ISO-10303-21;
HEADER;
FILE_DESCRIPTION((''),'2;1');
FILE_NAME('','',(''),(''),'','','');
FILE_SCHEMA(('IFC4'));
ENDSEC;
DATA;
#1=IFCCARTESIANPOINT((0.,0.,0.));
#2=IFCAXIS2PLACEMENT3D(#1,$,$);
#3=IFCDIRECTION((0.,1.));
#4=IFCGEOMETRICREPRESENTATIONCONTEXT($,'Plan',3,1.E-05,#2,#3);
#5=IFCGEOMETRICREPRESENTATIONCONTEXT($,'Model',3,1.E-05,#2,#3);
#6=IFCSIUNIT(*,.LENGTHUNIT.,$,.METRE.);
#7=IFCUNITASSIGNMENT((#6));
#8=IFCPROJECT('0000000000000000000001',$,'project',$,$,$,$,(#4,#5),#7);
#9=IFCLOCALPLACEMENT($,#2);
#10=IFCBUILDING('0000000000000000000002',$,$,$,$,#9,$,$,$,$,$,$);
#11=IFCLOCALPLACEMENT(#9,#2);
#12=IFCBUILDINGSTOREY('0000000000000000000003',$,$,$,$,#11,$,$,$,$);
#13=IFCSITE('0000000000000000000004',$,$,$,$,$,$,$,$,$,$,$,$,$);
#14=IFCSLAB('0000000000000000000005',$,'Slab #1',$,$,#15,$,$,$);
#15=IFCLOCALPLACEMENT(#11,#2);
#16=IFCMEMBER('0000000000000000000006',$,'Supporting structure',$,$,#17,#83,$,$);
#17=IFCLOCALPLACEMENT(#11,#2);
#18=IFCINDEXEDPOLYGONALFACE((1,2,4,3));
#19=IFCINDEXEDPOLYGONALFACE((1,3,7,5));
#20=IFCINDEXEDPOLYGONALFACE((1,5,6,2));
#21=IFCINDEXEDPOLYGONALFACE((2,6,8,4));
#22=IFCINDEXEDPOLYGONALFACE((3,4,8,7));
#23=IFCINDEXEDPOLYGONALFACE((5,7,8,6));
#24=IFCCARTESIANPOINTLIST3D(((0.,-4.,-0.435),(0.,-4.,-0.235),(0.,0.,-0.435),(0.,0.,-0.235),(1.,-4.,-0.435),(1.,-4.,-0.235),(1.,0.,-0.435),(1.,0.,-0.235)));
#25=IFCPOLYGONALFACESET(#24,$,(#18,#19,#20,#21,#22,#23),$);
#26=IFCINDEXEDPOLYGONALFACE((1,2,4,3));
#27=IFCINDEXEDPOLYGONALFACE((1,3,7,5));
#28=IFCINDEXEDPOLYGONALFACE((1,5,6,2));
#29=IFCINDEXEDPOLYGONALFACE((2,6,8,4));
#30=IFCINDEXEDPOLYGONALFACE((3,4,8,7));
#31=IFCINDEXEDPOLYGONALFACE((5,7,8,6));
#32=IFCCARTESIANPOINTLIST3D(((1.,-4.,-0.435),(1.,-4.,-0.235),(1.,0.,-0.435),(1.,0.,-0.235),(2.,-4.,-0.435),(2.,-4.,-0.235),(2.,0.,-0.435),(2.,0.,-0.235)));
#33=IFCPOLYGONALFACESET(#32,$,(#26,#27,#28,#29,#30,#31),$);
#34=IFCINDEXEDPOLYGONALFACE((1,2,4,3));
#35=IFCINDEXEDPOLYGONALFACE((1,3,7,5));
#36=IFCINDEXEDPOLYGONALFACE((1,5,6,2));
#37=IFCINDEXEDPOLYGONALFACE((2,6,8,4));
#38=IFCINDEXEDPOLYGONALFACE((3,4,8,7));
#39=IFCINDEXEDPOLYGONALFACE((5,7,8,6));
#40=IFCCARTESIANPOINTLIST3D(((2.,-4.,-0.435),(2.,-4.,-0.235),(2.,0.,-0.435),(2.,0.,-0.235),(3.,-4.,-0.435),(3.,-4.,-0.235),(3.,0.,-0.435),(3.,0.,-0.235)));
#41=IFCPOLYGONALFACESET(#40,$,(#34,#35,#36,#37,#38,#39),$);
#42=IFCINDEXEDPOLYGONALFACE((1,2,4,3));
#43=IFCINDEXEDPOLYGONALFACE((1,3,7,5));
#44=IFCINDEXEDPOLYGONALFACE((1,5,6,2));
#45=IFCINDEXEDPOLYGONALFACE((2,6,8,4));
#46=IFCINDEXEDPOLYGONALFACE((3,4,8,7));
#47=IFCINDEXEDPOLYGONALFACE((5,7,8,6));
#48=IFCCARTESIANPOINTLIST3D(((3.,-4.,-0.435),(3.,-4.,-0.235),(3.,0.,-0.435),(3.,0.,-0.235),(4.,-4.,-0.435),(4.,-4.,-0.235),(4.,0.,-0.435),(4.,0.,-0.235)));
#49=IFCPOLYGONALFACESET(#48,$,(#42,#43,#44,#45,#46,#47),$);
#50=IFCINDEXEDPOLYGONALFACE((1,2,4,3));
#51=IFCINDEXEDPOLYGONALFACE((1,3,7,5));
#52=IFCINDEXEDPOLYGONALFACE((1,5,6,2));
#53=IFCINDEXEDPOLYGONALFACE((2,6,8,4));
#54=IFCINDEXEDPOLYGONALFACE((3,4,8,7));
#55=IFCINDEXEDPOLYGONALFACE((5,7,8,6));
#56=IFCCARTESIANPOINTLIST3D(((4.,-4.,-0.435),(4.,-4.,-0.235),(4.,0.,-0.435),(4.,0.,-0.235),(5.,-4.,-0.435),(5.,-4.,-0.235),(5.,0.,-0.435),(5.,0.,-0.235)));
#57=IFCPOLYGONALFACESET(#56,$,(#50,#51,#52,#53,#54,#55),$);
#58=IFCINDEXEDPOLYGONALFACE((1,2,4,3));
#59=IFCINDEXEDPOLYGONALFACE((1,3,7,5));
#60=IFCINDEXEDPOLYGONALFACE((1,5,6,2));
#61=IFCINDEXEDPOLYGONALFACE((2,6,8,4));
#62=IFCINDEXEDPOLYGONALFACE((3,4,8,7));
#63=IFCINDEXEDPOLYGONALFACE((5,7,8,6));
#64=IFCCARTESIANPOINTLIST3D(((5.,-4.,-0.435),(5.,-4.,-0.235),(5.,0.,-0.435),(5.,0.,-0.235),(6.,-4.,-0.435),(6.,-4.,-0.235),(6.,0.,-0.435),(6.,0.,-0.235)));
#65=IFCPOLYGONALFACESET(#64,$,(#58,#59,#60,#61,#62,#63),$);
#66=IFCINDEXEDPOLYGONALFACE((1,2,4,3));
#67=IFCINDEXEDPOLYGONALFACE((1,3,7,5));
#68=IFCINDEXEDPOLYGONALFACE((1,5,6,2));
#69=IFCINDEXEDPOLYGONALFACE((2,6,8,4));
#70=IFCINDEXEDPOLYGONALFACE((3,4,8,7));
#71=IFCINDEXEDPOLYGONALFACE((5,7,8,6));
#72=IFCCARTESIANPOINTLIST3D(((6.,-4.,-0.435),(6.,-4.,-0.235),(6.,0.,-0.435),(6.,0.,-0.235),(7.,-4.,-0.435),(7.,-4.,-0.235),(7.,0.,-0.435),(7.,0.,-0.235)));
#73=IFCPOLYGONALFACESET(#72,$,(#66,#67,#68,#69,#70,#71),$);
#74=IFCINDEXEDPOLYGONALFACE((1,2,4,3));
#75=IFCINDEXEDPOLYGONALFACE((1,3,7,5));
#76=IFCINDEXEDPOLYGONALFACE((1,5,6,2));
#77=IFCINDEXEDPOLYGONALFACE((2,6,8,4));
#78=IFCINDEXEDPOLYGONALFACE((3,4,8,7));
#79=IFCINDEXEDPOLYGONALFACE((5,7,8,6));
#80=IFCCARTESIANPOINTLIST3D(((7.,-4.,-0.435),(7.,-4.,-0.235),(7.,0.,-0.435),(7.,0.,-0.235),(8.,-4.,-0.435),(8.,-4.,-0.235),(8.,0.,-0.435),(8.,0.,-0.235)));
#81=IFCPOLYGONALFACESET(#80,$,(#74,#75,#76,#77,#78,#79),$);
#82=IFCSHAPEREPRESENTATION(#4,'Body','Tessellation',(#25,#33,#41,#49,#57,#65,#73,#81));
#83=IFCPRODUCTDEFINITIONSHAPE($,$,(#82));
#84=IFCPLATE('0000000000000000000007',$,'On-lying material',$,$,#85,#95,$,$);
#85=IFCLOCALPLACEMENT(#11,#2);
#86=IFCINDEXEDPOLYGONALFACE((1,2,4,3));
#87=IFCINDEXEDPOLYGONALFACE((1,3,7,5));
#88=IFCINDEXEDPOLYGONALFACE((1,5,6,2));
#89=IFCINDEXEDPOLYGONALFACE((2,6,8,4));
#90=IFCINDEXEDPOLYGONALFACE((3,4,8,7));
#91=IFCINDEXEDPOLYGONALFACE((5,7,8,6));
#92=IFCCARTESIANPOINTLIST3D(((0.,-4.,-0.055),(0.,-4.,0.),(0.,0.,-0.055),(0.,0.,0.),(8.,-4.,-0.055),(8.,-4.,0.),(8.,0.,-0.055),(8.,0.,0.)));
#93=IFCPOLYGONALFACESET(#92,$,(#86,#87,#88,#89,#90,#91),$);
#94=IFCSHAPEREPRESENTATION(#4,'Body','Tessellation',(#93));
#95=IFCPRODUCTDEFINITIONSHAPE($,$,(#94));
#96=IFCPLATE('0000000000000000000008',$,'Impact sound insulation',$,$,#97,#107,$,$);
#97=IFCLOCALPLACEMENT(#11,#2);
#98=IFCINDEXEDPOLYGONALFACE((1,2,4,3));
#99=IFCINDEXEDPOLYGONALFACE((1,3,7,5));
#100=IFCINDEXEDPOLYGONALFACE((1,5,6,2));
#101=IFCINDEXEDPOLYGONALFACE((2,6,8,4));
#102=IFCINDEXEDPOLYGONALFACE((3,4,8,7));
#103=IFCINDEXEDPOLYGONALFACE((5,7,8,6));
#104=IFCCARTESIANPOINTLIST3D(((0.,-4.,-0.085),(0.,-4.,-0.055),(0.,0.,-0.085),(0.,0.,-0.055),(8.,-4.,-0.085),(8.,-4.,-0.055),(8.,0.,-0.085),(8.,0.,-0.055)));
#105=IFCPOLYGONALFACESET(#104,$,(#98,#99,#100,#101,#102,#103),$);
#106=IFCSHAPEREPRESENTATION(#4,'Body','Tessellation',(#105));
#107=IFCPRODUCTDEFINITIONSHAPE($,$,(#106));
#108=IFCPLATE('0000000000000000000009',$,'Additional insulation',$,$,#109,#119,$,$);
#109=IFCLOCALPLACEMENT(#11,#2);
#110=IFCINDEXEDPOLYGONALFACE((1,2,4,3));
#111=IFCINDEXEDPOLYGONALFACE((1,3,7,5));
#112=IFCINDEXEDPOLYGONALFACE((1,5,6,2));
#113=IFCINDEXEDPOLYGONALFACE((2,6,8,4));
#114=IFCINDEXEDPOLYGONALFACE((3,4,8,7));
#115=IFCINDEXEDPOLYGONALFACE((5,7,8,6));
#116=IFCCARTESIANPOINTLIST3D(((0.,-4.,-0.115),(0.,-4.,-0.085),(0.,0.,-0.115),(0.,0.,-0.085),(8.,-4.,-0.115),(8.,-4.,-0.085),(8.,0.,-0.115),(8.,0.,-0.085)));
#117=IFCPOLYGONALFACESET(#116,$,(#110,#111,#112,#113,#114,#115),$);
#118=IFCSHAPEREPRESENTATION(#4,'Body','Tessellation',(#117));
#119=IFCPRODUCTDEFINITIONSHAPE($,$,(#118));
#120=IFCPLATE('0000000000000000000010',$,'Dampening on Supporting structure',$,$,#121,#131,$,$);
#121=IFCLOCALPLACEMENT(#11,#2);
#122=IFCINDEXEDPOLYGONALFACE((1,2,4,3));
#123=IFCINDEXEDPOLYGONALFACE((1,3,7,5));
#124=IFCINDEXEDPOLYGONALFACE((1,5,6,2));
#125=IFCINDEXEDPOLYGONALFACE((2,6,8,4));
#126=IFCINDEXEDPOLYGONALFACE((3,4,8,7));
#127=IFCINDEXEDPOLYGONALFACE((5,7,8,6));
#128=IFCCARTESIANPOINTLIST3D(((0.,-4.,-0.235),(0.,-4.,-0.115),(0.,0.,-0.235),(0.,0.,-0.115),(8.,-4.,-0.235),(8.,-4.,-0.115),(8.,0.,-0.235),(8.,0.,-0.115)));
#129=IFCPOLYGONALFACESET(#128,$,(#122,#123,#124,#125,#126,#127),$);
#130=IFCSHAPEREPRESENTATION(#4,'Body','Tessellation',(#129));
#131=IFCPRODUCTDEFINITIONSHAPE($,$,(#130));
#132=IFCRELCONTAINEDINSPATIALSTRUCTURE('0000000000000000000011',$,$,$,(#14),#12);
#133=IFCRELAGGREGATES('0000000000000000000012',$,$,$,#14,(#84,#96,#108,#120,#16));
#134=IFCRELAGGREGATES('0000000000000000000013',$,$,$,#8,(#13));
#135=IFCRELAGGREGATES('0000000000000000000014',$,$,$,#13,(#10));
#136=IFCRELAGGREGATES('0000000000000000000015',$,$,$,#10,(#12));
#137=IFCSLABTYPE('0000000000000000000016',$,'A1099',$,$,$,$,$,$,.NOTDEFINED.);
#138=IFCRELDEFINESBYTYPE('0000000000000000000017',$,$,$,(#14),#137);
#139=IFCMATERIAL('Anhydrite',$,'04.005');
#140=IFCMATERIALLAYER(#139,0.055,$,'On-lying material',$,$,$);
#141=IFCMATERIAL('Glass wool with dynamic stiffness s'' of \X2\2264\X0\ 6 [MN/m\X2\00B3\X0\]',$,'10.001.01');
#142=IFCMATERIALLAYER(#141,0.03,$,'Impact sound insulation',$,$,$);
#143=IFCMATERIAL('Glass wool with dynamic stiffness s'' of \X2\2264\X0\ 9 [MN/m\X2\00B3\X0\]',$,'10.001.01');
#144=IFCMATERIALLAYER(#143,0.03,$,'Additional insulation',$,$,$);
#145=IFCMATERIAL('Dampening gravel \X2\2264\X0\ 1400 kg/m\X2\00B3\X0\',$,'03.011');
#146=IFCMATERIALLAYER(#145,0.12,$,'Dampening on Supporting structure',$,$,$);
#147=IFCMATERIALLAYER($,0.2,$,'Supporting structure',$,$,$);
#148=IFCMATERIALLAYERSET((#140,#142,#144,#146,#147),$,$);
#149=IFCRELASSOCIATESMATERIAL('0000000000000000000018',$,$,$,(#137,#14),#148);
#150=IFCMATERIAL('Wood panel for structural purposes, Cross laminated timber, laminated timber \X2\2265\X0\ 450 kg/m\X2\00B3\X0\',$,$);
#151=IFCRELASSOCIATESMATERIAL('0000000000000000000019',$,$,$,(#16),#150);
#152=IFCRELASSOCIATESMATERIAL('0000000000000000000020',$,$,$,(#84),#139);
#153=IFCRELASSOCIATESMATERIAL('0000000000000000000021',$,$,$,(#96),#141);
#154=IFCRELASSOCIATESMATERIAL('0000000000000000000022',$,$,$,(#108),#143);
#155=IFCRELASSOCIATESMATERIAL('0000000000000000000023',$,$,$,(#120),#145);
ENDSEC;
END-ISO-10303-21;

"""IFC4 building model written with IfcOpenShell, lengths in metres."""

from ifc_helpers import new_model, si_unit, direction, frame, frame_2d, origin, origin_with_axes, place, context, project, spatial, rectangle, extrude, material, layer, layer_set, type_object, element, aggregate, save


model = new_model("IFC4")

# Units and contexts
plan_context = context("Plan", 3, precision=1e-05, world=origin(), true_north=direction((0.0, 1.0)))
model_context = context("Model", 3, precision=1e-05, world=origin(), true_north=direction((0.0, 1.0)))
ifc_project = project(units=[si_unit("LENGTHUNIT", "METRE")], contexts=[plan_context, model_context])

# Site, building, storey
site = spatial("IfcSite", under=ifc_project)
building_placement = place(None, origin())
building = spatial("IfcBuilding", under=site, at=building_placement)
storey_placement = place(building_placement, origin())
storey = spatial("IfcBuildingStorey", under=building, at=storey_placement)

# Slab, member, plates
ifc_material_1 = material(Name="Anhydrite", Category="04.005")
ifc_layer_1 = layer(ifc_material_1, 0.055, Name="On-lying material")
ifc_material_2 = material(Name="Glass wool with dynamic stiffness s' of ≤ 6 [MN/m³]", Category="10.001.01")
ifc_layer_2 = layer(ifc_material_2, 0.03, Name="Impact sound insulation")
ifc_material_3 = material(Name="Glass wool with dynamic stiffness s' of ≤ 9 [MN/m³]", Category="10.001.01")
ifc_layer_3 = layer(ifc_material_3, 0.03, Name="Additional insulation")
ifc_material_4 = material(Name="Dampening gravel ≤ 1400 kg/m³", Category="03.011")
ifc_layer_4 = layer(ifc_material_4, 0.12, Name="Dampening on Supporting structure")
ifc_layer_5 = layer(None, 0.2, Name="Supporting structure")
ifc_layer_set = layer_set([ifc_layer_1, ifc_layer_2, ifc_layer_3, ifc_layer_4, ifc_layer_5])
slab_type = type_object("IfcSlabType", Name="A1099", PredefinedType="NOTDEFINED", material=ifc_layer_set)
slab_placement = place(None, frame((0.0, 0.0, 0.0), z_axis=(0.0, 0.0, -1.0), x_axis=(1.0, 0.0, 0.0)))
slab = element("IfcSlab", 1, at=slab_placement, inside=storey, type_object=slab_type, material=ifc_layer_set, Name="Slab #1")
ifc_material_5 = material(Name="Wood panel for structural purposes, Cross laminated timber, laminated timber ≥ 450 kg/m³")
member_placement = place(slab_placement, origin())
member = element("IfcMember", 2, at=member_placement, material=ifc_material_5, Name="Supporting structure", context=plan_context, shape_type="SweptSolid", body=[
    extrude(rectangle(XDim=1.0, YDim=0.2, at=frame_2d((0.5, 0.1), x_axis=(1.0, 0.0))), frame((0.0, 4.0, 0.235), z_axis=(0.0, -1.0, 0.0), x_axis=(1.0, 0.0, 0.0)), (0.0, 0.0, 1.0), 4.0),
    extrude(rectangle(XDim=1.0, YDim=0.2, at=frame_2d((0.5, 0.1), x_axis=(1.0, 0.0))), frame((1.0, 4.0, 0.235), z_axis=(0.0, -1.0, 0.0), x_axis=(1.0, 0.0, 0.0)), (0.0, 0.0, 1.0), 4.0),
    extrude(rectangle(XDim=1.0, YDim=0.2, at=frame_2d((0.5, 0.1), x_axis=(1.0, 0.0))), frame((2.0, 4.0, 0.235), z_axis=(0.0, -1.0, 0.0), x_axis=(1.0, 0.0, 0.0)), (0.0, 0.0, 1.0), 4.0),
    extrude(rectangle(XDim=1.0, YDim=0.2, at=frame_2d((0.5, 0.1), x_axis=(1.0, 0.0))), frame((3.0, 4.0, 0.235), z_axis=(0.0, -1.0, 0.0), x_axis=(1.0, 0.0, 0.0)), (0.0, 0.0, 1.0), 4.0),
    extrude(rectangle(XDim=1.0, YDim=0.2, at=frame_2d((0.5, 0.1), x_axis=(1.0, 0.0))), frame((4.0, 4.0, 0.235), z_axis=(0.0, -1.0, 0.0), x_axis=(1.0, 0.0, 0.0)), (0.0, 0.0, 1.0), 4.0),
    extrude(rectangle(XDim=1.0, YDim=0.2, at=frame_2d((0.5, 0.1), x_axis=(1.0, 0.0))), frame((5.0, 4.0, 0.235), z_axis=(0.0, -1.0, 0.0), x_axis=(1.0, 0.0, 0.0)), (0.0, 0.0, 1.0), 4.0),
    extrude(rectangle(XDim=1.0, YDim=0.2, at=frame_2d((0.5, 0.1), x_axis=(1.0, 0.0))), frame((6.0, 4.0, 0.235), z_axis=(0.0, -1.0, 0.0), x_axis=(1.0, 0.0, 0.0)), (0.0, 0.0, 1.0), 4.0),
    extrude(rectangle(XDim=1.0, YDim=0.2, at=frame_2d((0.5, 0.1), x_axis=(1.0, 0.0))), frame((7.0, 4.0, 0.235), z_axis=(0.0, -1.0, 0.0), x_axis=(1.0, 0.0, 0.0)), (0.0, 0.0, 1.0), 4.0),
])
plate_1_placement = place(slab_placement, origin())
plate_1 = element("IfcPlate", 3, at=plate_1_placement, material=ifc_material_1, Name="On-lying material", context=plan_context, shape_type="SweptSolid", body=[
    extrude(rectangle(XDim=8.0, YDim=4.0, at=frame_2d((4.0, 2.0), x_axis=(1.0, 0.0))), origin_with_axes(), (0.0, 0.0, 1.0), 0.055),
])
plate_2_placement = place(slab_placement, origin())
plate_2 = element("IfcPlate", 4, at=plate_2_placement, material=ifc_material_2, Name="Impact sound insulation", context=plan_context, shape_type="SweptSolid", body=[
    extrude(rectangle(XDim=8.0, YDim=4.0, at=frame_2d((4.0, 2.0), x_axis=(1.0, 0.0))), frame((0.0, 0.0, 0.055), z_axis=(0.0, 0.0, 1.0), x_axis=(1.0, 0.0, 0.0)), (0.0, 0.0, 1.0), 0.03),
])
plate_3_placement = place(slab_placement, origin())
plate_3 = element("IfcPlate", 5, at=plate_3_placement, material=ifc_material_3, Name="Additional insulation", context=plan_context, shape_type="SweptSolid", body=[
    extrude(rectangle(XDim=8.0, YDim=4.0, at=frame_2d((4.0, 2.0), x_axis=(1.0, 0.0))), frame((0.0, 0.0, 0.085), z_axis=(0.0, 0.0, 1.0), x_axis=(1.0, 0.0, 0.0)), (0.0, 0.0, 1.0), 0.03),
])
plate_4_placement = place(slab_placement, origin())
plate_4 = element("IfcPlate", 6, at=plate_4_placement, material=ifc_material_4, Name="Dampening on Supporting structure", context=plan_context, shape_type="SweptSolid", body=[
    extrude(rectangle(XDim=8.0, YDim=4.0, at=frame_2d((4.0, 2.0), x_axis=(1.0, 0.0))), frame((0.0, 0.0, 0.115), z_axis=(0.0, 0.0, 1.0), x_axis=(1.0, 0.0, 0.0)), (0.0, 0.0, 1.0), 0.12),
])
aggregate(slab, [plate_1, plate_2, plate_3, plate_4, member])

save(model, "model.ifc")
